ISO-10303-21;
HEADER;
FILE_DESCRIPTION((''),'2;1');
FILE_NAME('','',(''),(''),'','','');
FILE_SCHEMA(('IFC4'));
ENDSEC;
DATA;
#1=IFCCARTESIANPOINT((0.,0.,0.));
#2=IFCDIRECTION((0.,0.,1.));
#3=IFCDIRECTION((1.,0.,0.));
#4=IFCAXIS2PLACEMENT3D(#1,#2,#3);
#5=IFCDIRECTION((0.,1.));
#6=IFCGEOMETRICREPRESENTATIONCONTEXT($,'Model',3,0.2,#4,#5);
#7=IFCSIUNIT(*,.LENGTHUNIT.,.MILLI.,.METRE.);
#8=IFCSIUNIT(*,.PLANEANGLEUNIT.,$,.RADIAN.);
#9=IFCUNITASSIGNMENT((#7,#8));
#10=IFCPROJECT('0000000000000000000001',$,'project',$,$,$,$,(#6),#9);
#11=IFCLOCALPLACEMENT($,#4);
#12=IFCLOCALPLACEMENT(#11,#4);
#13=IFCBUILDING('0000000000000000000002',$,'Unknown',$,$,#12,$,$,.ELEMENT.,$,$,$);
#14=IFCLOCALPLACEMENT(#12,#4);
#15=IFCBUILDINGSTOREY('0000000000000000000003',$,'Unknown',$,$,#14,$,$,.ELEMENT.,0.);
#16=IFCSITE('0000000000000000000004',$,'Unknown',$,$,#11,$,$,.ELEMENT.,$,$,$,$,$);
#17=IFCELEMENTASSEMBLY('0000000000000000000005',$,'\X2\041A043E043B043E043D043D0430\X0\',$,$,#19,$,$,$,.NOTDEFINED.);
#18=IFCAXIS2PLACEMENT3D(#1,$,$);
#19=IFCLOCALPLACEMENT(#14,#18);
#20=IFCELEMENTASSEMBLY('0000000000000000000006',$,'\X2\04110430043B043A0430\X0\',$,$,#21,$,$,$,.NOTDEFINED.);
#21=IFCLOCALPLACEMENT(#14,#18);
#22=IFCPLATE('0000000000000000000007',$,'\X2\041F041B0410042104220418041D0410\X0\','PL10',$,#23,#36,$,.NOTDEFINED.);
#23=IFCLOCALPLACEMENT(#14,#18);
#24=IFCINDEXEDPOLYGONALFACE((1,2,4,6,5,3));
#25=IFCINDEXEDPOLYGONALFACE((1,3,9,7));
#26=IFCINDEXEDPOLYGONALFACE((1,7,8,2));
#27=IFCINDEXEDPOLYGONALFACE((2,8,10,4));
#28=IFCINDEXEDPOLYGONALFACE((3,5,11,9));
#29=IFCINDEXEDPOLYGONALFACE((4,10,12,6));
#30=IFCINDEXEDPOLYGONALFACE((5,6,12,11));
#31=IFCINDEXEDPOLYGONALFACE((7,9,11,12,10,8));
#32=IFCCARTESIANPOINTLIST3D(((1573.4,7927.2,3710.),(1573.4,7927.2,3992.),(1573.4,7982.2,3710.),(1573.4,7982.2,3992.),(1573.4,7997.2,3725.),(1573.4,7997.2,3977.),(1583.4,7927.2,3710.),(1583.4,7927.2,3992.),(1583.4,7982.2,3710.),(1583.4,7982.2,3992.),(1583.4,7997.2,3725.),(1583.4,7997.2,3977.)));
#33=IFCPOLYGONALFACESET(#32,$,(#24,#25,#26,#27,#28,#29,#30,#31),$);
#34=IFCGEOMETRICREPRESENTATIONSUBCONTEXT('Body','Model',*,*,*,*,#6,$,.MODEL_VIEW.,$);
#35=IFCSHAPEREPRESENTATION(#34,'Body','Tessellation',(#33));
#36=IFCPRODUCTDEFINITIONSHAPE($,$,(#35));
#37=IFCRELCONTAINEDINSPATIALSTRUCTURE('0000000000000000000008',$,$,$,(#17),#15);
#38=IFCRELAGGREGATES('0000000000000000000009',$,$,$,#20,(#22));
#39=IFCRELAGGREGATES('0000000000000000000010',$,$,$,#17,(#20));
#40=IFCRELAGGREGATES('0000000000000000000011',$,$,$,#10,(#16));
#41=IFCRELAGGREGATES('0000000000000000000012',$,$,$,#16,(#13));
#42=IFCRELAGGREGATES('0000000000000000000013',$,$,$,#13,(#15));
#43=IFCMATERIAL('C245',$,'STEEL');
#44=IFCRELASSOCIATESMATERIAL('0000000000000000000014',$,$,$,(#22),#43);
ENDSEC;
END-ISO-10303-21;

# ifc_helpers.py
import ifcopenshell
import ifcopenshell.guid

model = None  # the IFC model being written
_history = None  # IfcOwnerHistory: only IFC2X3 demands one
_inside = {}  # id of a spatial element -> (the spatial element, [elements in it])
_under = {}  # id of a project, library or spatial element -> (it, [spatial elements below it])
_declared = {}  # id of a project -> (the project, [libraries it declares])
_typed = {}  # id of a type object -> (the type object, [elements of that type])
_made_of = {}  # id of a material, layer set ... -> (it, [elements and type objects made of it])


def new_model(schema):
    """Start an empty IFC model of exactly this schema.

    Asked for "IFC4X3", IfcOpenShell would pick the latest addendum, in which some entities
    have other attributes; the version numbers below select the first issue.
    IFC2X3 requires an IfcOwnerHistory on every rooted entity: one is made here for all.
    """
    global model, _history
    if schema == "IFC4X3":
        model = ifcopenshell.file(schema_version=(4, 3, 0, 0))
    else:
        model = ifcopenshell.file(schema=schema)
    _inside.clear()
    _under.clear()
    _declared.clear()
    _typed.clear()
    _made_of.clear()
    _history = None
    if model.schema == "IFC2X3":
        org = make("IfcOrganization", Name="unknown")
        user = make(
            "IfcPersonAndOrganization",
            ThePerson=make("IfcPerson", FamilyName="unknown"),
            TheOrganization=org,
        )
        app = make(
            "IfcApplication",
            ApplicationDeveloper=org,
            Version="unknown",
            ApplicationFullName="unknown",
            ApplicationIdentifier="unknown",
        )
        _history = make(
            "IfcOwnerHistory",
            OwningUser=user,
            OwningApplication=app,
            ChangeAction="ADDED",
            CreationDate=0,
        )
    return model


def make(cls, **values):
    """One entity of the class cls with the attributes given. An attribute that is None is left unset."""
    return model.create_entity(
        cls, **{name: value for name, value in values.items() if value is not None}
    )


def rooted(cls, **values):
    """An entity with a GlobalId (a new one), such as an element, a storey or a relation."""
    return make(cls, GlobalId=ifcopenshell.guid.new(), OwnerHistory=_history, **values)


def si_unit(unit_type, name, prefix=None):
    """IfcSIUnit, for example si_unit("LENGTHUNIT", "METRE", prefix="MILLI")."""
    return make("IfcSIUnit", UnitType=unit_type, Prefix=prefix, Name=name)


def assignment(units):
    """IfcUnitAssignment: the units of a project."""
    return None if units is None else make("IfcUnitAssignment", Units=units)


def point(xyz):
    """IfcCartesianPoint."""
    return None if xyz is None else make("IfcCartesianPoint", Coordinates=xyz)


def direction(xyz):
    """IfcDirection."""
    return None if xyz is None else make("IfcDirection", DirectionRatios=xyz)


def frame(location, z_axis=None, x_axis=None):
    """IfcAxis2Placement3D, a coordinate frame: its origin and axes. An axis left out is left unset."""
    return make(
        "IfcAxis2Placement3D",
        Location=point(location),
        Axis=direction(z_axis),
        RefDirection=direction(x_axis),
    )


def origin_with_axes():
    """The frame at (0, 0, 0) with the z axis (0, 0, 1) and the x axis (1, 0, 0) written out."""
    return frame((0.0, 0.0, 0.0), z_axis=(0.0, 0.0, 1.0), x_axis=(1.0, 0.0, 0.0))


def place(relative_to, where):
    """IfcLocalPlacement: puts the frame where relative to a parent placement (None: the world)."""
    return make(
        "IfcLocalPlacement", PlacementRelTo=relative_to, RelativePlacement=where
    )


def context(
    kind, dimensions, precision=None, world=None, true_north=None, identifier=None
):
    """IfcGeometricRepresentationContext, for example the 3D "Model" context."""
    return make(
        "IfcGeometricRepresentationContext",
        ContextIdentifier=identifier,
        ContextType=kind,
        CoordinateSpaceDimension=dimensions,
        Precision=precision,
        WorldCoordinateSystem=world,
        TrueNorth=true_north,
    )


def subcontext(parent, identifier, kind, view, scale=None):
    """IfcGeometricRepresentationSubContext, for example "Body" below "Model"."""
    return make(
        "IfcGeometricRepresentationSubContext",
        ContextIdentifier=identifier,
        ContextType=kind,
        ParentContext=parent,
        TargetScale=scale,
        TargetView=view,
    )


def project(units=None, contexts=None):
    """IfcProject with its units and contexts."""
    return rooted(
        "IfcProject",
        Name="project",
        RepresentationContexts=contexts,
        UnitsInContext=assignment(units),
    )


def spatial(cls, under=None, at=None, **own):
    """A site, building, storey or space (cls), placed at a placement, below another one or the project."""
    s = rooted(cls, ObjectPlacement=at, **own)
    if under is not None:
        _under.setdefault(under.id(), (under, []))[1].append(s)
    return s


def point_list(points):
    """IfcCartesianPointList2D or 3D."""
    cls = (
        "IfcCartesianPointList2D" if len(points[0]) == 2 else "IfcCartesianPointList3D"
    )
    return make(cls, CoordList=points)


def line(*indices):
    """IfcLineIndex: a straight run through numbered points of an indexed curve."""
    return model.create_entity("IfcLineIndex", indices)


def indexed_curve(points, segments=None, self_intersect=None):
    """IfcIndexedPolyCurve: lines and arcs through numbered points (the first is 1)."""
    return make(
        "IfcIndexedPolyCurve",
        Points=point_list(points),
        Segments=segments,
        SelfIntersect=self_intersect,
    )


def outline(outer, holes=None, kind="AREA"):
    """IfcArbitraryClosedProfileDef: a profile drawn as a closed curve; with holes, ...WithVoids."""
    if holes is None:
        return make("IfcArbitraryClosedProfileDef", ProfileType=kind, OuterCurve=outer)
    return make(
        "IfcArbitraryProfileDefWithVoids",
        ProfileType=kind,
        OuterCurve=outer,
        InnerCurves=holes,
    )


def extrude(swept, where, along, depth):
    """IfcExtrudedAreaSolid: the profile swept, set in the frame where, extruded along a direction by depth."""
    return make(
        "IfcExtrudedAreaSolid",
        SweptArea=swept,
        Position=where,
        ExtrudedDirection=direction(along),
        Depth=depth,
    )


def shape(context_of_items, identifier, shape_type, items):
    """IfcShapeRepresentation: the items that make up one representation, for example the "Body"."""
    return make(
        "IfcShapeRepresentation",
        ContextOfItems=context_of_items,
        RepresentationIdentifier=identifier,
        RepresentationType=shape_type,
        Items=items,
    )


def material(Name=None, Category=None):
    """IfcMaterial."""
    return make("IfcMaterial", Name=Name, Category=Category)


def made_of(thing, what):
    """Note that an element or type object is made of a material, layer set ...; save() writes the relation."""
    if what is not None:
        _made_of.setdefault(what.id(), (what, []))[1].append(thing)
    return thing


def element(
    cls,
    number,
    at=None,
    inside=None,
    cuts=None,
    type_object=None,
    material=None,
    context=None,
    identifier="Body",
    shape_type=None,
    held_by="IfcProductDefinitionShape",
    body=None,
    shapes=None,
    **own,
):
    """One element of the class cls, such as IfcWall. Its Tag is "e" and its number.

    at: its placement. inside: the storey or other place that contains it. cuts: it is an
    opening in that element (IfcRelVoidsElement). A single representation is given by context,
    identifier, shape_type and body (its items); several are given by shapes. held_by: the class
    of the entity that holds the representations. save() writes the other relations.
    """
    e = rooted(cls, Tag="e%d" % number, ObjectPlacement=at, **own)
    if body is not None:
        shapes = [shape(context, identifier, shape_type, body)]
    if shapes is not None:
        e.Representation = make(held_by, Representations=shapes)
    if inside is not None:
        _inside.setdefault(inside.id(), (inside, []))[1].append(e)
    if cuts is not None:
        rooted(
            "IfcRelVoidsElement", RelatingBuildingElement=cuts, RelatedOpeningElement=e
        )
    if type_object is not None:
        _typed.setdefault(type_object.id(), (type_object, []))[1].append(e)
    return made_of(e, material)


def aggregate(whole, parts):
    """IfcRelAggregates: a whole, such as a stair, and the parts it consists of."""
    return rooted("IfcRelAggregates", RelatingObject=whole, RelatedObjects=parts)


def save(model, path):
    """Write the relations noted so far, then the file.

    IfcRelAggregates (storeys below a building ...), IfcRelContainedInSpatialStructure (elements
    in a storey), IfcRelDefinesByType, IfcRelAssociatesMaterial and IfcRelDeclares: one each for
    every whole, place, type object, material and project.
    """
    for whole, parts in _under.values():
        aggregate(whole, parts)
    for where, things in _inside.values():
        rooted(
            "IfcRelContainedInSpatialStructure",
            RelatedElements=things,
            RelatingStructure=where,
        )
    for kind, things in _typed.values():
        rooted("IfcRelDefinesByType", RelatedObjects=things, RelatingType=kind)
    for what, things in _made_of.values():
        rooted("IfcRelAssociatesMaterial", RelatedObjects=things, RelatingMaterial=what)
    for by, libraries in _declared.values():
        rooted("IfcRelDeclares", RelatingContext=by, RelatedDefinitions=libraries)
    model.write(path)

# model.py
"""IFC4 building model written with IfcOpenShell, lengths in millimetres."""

from ifc_helpers import new_model, si_unit, direction, frame, origin_with_axes, place, context, subcontext, project, spatial, line, indexed_curve, outline, extrude, material, element, aggregate, save


model = new_model("IFC4")

# Units and contexts
model_context = context("Model", 3, precision=0.2, world=origin_with_axes(), true_north=direction((0.0, 1.0)))
body_context = subcontext(model_context, "Body", "Model", "MODEL_VIEW")
ifc_project = project(units=[si_unit("LENGTHUNIT", "METRE", prefix="MILLI"), si_unit("PLANEANGLEUNIT", "RADIAN")], contexts=[model_context])

# Site, building, storey
site_placement = place(None, origin_with_axes())
site = spatial("IfcSite", under=ifc_project, at=site_placement, Name="Unknown", CompositionType="ELEMENT")
building_placement = place(site_placement, origin_with_axes())
building = spatial("IfcBuilding", under=site, at=building_placement, Name="Unknown", CompositionType="ELEMENT")
storey_placement = place(building_placement, origin_with_axes())
storey = spatial("IfcBuildingStorey", under=building, at=storey_placement, Name="Unknown", CompositionType="ELEMENT", Elevation=0.0)

# Element assemblies, plate
ifc_material_1 = material(Name="C245", Category="STEEL")
assembly_1_placement = place(storey_placement, frame((0.0, 8000.0, 0.0), z_axis=(0.0, -1.0, 0.0), x_axis=(0.0, 0.0, 1.0)))
assembly_1 = element("IfcElementAssembly", 1, at=assembly_1_placement, inside=storey, Name="Колонна", PredefinedType="NOTDEFINED")
assembly_2_placement = place(assembly_1_placement, frame((3851.0, 0.0, 0.0), z_axis=(0.0, 0.0, 1.0), x_axis=(0.0, -1.0, 0.0)))
assembly_2 = element("IfcElementAssembly", 2, at=assembly_2_placement, Name="Балка", PredefinedType="NOTDEFINED")
plate_1_placement = place(assembly_2_placement, frame((1578.4, -141.0, 72.8), z_axis=(1.0, 0.0, 0.0), x_axis=(0.0, 0.0, -1.0)))
plate_1 = element("IfcPlate", 3, at=plate_1_placement, material=ifc_material_1, Name="ПЛАСТИНА", Description="PL10", PredefinedType="NOTDEFINED", context=body_context, shape_type="SolidModel", body=[
    extrude(outline(indexed_curve([(0.0, 0.0), (55.0, 0.0), (70.0, 15.0), (70.0, 267.0), (55.0, 282.0), (0.0, 282.0)], segments=[line(1, 2, 3, 4, 5, 6, 1)])), frame((0.0, 0.0, 5.0), z_axis=(0.0, 0.0, 1.0), x_axis=(1.0, 0.0, 0.0)), (0.0, 0.0, -1.0), 10.0),
])
aggregate(assembly_2, [plate_1])

aggregate(assembly_1, [assembly_2])

save(model, "model.ifc")
